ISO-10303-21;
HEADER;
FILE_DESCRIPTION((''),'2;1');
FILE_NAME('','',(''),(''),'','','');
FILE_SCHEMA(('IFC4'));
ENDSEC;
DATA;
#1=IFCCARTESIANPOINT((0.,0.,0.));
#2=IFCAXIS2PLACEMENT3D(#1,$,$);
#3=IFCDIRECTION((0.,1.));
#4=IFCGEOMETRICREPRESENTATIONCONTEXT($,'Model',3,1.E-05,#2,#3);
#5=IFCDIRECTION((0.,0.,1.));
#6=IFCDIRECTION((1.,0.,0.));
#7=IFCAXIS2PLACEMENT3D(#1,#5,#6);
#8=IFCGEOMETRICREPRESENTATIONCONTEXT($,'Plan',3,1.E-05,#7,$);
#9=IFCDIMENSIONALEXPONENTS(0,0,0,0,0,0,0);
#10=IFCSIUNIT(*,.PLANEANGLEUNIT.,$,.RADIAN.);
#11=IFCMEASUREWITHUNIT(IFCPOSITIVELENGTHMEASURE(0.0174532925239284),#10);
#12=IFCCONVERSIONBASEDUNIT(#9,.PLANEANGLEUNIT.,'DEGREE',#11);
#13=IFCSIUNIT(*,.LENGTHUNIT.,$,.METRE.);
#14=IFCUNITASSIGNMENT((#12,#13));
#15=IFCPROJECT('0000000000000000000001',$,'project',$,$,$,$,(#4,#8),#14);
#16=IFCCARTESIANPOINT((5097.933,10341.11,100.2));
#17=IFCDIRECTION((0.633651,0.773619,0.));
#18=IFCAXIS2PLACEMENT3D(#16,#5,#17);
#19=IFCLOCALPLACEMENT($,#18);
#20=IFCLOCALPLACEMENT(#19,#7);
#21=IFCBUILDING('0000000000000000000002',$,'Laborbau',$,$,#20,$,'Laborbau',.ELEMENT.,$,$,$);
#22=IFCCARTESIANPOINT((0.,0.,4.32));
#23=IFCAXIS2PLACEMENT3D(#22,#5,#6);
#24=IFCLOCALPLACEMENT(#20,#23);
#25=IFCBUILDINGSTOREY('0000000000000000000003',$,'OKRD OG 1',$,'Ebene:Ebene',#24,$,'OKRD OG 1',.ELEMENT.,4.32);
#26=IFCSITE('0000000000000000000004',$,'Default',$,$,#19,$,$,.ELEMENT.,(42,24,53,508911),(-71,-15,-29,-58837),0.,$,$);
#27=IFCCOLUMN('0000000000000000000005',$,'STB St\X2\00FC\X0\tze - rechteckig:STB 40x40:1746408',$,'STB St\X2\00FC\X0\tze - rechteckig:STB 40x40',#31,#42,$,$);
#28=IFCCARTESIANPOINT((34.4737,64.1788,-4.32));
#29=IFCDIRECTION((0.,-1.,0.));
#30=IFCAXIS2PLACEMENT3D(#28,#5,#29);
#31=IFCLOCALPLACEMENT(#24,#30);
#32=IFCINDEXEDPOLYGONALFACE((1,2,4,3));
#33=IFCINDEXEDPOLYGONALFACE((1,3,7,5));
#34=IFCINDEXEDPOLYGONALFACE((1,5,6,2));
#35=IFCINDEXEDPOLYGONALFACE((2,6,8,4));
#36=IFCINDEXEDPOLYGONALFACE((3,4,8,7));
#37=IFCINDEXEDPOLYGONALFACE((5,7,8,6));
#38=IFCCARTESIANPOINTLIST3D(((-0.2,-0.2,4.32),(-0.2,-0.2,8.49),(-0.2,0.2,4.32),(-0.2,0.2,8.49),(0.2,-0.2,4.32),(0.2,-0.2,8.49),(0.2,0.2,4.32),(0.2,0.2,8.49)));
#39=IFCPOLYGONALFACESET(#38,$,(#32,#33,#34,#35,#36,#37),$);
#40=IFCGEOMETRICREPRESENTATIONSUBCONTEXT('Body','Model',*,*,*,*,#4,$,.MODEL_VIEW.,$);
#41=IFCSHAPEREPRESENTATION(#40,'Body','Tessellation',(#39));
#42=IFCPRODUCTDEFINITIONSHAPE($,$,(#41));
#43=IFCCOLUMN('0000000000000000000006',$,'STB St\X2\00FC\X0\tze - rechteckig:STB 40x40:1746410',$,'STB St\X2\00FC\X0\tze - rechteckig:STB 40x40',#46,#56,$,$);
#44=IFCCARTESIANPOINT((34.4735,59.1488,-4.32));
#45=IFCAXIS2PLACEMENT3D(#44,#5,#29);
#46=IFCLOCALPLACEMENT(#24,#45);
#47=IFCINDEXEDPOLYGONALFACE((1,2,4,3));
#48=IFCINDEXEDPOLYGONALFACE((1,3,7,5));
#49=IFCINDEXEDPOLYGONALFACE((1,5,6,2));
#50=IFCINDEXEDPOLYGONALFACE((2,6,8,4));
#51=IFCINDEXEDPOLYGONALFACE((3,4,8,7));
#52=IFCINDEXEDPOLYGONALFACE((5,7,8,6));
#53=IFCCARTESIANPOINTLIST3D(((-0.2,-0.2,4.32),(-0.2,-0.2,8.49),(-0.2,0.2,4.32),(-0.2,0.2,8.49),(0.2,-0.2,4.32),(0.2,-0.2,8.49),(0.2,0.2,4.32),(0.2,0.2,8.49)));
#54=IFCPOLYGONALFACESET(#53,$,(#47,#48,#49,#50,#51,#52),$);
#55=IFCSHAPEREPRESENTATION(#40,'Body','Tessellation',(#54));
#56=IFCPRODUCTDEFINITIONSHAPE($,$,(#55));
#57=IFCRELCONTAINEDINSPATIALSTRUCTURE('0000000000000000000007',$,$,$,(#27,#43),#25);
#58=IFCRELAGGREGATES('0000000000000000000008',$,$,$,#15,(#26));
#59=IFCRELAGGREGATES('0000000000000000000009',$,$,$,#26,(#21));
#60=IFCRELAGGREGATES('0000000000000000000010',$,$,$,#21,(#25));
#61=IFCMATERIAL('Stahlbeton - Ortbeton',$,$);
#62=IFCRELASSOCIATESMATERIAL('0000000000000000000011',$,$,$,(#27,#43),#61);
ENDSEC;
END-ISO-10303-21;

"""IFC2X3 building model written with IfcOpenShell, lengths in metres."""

from ifc_helpers import new_model, entity, si_unit, converted_unit, direction, frame, origin, origin_with_axes, origin_2d_with_axis, place, context, subcontext, project, spatial, rectangle, extrude, source, transform, mapped, material, element, save


model = new_model("IFC2X3")

# Units and contexts
model_context = context("Model", 3, precision=1e-05, world=origin(), true_north=direction((0.0, 1.0)))
plan_context = context("Plan", 3, precision=1e-05, world=origin_with_axes())
body_context = subcontext(model_context, "Body", "Model", "MODEL_VIEW")
ifc_project = project(units=[converted_unit("PLANEANGLEUNIT", "DEGREE", entity("IfcPositiveLengthMeasure", 0.0174532925239284), si_unit("PLANEANGLEUNIT", "RADIAN"), dimensions=[0, 0, 0, 0, 0, 0, 0]), si_unit("LENGTHUNIT", "METRE")], contexts=[model_context, plan_context])

# Site, building, storey
site_placement = place(None, frame((5097.933, 10341.11, 100.2), z_axis=(0.0, 0.0, 1.0), x_axis=(0.633651, 0.773619, 0.0)))
site = spatial("IfcSite", under=ifc_project, at=site_placement, Name="Default", CompositionType="ELEMENT", RefLatitude=(42, 24, 53, 508911), RefLongitude=(-71, -15, -29, -58837), RefElevation=0.0)
building_placement = place(site_placement, origin_with_axes())
building = spatial("IfcBuilding", under=site, at=building_placement, Name="Laborbau", LongName="Laborbau", CompositionType="ELEMENT")
storey_placement = place(building_placement, frame((0.0, 0.0, 4.32), z_axis=(0.0, 0.0, 1.0), x_axis=(1.0, 0.0, 0.0)))
storey = spatial("IfcBuildingStorey", under=building, at=storey_placement, Name="OKRD OG 1", ObjectType="Ebene:Ebene", LongName="OKRD OG 1", CompositionType="ELEMENT", Elevation=4.32)

# Columns
ifc_material_1 = material(Name="Stahlbeton - Ortbeton")
shared_shape = source(origin(), body_context, "Body", "SweptSolid", [
    extrude(rectangle(XDim=0.4, YDim=0.4, at=origin_2d_with_axis()), frame((0.0, 0.0, 4.32), z_axis=(0.0, 0.0, 1.0), x_axis=(0.0, -1.0, 0.0)), (0.0, 0.0, 1.0), 4.17),
])
for number, where, z_axis, x_axis, name in (
    (1, (34.4737, 64.1788, -4.32), (0.0, 0.0, 1.0), (0.0, -1.0, 0.0), "STB Stütze - rechteckig:STB 40x40:1746408"),
    (2, (34.4735, 59.1488, -4.32), (0.0, 0.0, 1.0), (0.0, -1.0, 0.0), "STB Stütze - rechteckig:STB 40x40:1746410"),
):
    element("IfcColumn", number, at=place(storey_placement, frame(where, z_axis=z_axis, x_axis=x_axis)), inside=storey, material=ifc_material_1, Name=name, ObjectType="STB Stütze - rechteckig:STB 40x40", context=body_context, shape_type="MappedRepresentation", body=[
        mapped(shared_shape, transform((0.0, 0.0, 0.0), scale=1.0)),
    ])

save(model, "model.ifc")
